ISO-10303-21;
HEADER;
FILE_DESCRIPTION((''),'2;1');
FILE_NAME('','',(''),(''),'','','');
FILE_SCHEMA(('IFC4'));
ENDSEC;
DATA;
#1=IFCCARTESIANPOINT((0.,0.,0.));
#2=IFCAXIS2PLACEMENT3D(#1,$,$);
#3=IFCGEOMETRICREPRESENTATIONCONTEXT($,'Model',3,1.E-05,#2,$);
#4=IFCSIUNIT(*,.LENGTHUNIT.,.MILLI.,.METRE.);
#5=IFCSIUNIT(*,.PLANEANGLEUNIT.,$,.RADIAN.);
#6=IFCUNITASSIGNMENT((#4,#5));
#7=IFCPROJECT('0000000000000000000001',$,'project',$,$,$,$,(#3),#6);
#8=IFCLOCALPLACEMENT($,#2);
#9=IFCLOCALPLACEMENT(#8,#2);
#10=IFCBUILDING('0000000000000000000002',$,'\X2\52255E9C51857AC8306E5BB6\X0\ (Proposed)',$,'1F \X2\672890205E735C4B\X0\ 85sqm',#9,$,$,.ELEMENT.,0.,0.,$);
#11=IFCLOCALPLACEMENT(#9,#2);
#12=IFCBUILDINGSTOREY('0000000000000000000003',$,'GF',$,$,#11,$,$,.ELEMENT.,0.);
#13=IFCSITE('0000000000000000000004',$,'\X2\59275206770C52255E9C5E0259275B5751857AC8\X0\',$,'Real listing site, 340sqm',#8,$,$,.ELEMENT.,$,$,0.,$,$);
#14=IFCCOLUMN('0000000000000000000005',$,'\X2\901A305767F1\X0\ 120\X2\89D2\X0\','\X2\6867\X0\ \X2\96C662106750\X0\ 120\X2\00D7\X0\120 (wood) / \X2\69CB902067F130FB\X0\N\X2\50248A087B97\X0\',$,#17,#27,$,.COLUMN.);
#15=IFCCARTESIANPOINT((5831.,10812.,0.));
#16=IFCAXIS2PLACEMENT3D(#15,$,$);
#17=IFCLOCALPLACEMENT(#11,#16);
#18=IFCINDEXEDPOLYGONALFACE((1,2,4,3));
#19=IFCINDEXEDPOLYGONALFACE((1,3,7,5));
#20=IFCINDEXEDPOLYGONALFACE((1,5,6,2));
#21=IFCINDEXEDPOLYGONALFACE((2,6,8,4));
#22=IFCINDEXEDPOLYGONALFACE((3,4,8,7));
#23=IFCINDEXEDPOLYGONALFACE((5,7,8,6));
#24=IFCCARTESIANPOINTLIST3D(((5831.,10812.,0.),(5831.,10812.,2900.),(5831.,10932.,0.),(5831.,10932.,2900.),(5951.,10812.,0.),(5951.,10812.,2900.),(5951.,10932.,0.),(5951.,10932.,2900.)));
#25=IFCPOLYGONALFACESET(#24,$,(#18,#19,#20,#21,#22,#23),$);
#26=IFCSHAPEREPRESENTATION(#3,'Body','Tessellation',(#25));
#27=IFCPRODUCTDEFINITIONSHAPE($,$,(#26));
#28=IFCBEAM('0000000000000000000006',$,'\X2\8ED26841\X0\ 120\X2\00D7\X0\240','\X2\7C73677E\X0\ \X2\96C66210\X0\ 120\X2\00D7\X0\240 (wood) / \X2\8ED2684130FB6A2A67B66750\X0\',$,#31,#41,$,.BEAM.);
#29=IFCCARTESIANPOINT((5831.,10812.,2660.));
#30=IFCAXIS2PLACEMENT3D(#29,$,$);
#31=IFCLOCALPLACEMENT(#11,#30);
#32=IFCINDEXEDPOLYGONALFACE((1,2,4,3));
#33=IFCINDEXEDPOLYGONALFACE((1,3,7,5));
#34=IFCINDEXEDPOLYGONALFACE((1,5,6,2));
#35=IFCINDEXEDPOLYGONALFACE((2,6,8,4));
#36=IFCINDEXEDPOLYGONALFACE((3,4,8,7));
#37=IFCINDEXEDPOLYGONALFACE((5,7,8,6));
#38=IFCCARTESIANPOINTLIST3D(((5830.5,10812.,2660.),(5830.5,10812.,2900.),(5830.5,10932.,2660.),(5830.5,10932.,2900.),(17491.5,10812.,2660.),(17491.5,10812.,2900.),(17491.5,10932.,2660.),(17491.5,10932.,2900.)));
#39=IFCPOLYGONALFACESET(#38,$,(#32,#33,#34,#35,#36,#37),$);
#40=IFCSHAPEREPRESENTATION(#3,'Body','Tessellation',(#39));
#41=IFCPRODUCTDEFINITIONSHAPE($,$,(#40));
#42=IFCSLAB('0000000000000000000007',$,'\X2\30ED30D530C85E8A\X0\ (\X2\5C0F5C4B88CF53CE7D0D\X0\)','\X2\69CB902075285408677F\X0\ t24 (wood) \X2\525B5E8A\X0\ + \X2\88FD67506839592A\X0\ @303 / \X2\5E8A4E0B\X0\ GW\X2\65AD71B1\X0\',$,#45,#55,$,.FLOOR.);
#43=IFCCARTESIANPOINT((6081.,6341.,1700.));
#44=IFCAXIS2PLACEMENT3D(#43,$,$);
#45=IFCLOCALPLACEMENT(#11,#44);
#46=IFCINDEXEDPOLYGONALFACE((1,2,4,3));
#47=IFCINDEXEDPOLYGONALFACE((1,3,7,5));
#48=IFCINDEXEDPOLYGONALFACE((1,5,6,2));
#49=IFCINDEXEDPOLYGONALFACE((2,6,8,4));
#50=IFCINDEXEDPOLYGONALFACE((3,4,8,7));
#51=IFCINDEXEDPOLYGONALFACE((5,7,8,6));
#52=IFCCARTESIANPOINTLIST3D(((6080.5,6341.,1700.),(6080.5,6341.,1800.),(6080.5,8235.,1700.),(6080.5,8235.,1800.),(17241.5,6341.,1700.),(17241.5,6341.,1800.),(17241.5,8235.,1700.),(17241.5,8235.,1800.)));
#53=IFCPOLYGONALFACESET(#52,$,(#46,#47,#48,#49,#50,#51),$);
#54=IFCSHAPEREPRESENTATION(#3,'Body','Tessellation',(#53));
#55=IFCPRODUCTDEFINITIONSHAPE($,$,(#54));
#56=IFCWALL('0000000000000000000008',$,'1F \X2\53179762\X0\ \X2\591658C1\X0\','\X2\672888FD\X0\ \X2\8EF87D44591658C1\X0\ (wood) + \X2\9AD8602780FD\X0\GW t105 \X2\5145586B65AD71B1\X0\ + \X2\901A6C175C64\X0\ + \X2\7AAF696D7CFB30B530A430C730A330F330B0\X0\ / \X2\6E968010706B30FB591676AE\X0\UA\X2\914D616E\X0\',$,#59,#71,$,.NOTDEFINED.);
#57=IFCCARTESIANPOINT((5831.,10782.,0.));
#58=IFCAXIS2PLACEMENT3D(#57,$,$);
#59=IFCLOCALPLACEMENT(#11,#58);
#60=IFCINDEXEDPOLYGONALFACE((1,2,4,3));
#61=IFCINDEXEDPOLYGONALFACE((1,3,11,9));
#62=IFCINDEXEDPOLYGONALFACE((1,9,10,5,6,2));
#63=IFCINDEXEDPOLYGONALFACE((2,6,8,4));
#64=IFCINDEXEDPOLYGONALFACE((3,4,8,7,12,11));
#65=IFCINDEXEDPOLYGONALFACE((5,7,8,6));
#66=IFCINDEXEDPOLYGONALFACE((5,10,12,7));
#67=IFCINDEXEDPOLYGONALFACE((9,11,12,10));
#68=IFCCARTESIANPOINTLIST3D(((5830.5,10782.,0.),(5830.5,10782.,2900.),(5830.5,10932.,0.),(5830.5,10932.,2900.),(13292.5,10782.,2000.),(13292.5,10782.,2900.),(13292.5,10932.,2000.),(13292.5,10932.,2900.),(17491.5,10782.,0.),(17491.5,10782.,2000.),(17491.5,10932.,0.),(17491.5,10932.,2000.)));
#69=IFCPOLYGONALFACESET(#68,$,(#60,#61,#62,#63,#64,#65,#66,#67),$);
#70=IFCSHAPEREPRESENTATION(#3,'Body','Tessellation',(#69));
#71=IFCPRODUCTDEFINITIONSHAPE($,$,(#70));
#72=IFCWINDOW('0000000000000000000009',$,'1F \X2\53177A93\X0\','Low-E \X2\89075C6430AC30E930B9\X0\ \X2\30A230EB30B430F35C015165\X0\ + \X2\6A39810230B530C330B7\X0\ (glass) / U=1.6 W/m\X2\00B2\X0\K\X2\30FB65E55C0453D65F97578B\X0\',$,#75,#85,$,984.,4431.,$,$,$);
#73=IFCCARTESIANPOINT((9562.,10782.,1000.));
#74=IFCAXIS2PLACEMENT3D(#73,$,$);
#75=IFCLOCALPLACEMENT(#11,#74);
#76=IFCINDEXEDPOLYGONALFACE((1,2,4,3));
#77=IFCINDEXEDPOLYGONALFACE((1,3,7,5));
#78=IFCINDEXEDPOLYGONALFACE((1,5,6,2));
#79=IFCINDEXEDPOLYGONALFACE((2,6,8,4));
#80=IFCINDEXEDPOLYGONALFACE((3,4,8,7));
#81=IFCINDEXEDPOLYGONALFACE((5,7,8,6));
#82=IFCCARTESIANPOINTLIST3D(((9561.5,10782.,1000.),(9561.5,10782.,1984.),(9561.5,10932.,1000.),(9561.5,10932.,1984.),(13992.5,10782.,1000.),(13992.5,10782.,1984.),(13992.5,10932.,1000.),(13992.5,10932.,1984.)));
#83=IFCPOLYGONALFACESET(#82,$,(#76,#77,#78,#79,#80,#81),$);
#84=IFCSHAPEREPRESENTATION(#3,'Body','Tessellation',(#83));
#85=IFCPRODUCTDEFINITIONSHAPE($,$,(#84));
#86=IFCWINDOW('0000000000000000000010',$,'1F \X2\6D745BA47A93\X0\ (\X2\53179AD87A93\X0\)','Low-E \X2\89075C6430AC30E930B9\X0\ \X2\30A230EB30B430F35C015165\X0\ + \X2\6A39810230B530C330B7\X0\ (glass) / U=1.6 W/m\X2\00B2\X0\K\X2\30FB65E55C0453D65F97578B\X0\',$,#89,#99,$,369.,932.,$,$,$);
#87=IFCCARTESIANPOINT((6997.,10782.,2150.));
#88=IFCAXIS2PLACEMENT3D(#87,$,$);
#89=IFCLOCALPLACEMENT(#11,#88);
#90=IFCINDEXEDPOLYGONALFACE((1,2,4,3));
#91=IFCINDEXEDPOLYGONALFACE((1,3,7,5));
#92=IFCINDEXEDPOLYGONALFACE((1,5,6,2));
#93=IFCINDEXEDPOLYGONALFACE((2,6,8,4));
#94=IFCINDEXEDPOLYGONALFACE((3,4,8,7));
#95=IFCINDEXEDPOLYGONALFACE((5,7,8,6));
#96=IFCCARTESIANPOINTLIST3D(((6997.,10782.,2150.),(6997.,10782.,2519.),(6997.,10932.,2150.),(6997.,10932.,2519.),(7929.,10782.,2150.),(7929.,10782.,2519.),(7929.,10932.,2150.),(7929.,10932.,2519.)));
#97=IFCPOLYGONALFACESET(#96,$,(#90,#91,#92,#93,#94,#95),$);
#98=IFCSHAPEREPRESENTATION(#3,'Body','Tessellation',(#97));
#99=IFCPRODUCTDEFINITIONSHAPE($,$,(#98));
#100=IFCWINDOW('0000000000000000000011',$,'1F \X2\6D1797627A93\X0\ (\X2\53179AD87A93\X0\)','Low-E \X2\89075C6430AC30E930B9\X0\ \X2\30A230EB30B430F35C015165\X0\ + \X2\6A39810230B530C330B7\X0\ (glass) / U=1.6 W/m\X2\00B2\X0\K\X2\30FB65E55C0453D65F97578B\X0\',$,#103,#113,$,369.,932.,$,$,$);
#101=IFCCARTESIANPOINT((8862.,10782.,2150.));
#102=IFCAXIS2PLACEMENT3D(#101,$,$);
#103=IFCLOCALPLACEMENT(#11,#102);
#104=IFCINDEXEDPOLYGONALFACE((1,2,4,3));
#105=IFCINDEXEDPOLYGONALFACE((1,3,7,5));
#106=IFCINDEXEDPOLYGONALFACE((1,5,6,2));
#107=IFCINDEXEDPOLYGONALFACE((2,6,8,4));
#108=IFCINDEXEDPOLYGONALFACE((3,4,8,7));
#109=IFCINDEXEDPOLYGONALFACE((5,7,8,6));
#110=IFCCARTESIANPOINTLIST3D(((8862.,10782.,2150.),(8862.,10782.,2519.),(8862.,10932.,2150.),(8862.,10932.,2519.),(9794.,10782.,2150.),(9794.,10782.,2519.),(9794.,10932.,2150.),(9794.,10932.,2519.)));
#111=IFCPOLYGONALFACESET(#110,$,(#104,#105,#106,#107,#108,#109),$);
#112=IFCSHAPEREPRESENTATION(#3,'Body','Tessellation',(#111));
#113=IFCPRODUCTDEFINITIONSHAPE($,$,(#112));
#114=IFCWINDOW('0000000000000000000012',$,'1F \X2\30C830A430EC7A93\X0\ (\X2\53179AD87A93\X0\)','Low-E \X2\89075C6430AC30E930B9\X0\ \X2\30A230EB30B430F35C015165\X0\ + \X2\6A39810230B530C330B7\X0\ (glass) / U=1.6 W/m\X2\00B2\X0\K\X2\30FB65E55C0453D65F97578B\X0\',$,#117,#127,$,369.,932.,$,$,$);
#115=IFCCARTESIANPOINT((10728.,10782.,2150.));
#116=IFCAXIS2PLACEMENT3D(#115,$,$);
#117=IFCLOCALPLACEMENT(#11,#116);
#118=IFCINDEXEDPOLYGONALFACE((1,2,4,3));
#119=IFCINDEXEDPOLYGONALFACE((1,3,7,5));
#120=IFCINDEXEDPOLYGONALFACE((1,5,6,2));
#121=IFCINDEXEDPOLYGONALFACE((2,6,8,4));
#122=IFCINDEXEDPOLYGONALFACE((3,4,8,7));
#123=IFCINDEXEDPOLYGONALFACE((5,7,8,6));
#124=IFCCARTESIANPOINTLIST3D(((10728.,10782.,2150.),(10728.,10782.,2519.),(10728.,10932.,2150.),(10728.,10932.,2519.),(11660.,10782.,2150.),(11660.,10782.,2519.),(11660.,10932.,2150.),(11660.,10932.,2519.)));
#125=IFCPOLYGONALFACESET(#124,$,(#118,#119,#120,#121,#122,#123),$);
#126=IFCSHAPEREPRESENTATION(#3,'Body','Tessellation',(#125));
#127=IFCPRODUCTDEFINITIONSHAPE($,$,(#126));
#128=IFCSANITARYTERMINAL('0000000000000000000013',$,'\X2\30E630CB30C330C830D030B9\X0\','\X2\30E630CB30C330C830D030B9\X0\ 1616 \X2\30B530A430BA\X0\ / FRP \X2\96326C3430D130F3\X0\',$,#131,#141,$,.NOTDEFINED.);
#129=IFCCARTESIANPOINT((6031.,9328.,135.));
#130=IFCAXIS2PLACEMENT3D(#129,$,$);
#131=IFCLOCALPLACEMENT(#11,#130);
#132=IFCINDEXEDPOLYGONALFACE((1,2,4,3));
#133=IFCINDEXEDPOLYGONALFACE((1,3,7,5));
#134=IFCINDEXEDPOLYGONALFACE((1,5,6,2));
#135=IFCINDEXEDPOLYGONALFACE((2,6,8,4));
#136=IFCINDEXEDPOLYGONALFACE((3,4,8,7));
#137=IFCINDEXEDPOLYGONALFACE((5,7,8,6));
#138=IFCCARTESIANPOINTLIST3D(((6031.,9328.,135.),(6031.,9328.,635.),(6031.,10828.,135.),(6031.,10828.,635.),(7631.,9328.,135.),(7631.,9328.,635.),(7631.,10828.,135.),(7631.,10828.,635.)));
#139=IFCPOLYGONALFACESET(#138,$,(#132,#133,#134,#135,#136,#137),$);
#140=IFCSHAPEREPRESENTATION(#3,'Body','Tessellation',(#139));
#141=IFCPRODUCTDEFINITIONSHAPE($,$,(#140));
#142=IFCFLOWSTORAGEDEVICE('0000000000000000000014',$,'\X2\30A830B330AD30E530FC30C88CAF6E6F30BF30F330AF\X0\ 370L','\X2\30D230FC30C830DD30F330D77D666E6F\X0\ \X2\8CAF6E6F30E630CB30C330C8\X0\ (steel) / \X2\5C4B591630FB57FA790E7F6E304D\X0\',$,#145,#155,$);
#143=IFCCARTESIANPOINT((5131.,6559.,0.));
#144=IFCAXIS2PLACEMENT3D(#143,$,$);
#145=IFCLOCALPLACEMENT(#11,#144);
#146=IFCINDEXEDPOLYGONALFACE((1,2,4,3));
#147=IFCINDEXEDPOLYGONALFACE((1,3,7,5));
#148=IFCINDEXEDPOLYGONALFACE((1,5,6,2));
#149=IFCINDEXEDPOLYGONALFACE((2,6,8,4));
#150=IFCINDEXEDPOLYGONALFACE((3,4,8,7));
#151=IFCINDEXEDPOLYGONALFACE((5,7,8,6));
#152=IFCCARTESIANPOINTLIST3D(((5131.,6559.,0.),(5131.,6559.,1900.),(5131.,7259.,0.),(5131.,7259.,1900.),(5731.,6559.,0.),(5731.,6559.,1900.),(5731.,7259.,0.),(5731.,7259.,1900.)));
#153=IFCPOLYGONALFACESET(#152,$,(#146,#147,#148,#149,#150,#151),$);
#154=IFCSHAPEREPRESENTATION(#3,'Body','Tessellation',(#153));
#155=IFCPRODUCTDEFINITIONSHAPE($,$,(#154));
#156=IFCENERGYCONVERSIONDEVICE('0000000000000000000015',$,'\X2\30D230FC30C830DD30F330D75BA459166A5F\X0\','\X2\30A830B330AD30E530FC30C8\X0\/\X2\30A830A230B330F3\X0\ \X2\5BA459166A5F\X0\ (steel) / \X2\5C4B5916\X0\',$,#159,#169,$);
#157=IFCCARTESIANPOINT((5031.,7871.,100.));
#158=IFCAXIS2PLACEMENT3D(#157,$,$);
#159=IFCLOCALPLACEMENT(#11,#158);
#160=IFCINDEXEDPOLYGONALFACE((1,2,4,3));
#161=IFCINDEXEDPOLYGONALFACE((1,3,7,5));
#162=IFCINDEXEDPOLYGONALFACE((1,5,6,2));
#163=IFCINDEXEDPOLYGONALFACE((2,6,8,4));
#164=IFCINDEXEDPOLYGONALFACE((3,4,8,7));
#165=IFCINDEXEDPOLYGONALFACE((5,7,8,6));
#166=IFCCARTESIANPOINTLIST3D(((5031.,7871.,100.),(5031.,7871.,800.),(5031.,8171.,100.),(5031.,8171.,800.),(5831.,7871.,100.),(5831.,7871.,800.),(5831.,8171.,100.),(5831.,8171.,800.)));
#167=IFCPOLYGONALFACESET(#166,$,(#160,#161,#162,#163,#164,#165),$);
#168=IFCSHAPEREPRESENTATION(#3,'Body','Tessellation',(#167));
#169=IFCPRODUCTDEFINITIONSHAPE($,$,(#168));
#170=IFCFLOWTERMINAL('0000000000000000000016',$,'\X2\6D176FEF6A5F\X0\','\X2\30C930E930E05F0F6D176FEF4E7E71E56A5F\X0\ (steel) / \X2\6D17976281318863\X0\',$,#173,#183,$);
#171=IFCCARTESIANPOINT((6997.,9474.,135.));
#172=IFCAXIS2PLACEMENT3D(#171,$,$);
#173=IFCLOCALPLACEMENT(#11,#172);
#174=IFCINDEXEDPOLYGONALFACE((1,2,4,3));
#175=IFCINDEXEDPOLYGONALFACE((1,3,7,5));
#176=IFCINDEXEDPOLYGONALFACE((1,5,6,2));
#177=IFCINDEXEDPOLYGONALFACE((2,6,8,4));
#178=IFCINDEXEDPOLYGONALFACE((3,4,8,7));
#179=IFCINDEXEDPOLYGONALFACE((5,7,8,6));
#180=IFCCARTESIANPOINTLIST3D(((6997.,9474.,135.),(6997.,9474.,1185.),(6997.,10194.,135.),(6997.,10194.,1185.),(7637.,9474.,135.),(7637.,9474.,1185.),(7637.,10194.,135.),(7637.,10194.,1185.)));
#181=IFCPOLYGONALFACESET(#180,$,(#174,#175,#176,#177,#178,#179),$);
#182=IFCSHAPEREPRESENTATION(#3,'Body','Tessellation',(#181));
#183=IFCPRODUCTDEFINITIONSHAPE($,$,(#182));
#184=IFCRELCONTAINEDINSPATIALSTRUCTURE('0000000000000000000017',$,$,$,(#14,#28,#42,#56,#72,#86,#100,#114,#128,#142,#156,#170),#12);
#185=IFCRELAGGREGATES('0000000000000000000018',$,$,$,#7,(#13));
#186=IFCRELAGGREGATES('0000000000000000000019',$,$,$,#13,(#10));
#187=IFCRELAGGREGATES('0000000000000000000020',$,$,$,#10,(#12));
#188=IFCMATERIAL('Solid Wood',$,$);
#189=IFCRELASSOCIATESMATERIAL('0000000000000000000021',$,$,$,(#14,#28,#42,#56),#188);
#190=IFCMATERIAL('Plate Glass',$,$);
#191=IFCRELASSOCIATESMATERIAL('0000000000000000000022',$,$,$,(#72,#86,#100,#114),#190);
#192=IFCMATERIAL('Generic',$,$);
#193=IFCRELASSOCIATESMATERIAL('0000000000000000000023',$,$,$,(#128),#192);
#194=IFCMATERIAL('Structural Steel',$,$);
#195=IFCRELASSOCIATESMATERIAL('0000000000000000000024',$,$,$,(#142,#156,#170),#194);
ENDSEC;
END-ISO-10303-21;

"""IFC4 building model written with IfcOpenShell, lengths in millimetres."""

from ifc_helpers import new_model, si_unit, frame, frame_2d, origin, place, context, project, spatial, rectangle, extrude, material, element, fill, save


model = new_model("IFC4")

# Units and contexts
model_context = context("Model", 3, precision=1e-05, world=origin())
ifc_project = project(units=[si_unit("LENGTHUNIT", "METRE", prefix="MILLI"), si_unit("PLANEANGLEUNIT", "RADIAN")], contexts=[model_context])

# Site, building, storey
site_placement = place(None, origin())
site = spatial("IfcSite", under=ifc_project, at=site_placement, Name="大分県別府市大字内竈", ObjectType="Real listing site, 340sqm", CompositionType="ELEMENT", RefElevation=0.0)
building_placement = place(site_placement, origin())
building = spatial("IfcBuilding", under=site, at=building_placement, Name="別府内竈の家 (Proposed)", ObjectType="1F 木造平屋 85sqm", CompositionType="ELEMENT", ElevationOfRefHeight=0.0, ElevationOfTerrain=0.0)
storey_placement = place(building_placement, origin())
storey = spatial("IfcBuildingStorey", under=building, at=storey_placement, Name="GF", CompositionType="ELEMENT", Elevation=0.0)

# Column
ifc_material_1 = material(Name="Solid Wood")
column_1_placement = place(storey_placement, frame((5831.0, 10812.0, 0.0)))
element("IfcColumn", 1, at=column_1_placement, inside=storey, material=ifc_material_1, Name="通し柱 120角", Description="桧 集成材 120×120 (wood) / 構造柱・N値計算", PredefinedType="COLUMN", context=model_context, shape_type="SweptSolid", body=[
    extrude(rectangle(XDim=120.0, YDim=120.0, at=frame_2d((60.0, 60.0))), frame((5831.0, 10812.0, 0.0)), (0.0, 0.0, 1.0), 2900.0),
])

# Beam
beam_1_placement = place(storey_placement, frame((5831.0, 10812.0, 2660.0)))
element("IfcBeam", 2, at=beam_1_placement, inside=storey, material=ifc_material_1, Name="軒桁 120×240", Description="米松 集成 120×240 (wood) / 軒桁・横架材", PredefinedType="BEAM", context=model_context, shape_type="SweptSolid", body=[
    extrude(rectangle(XDim=11661.0, YDim=120.0, at=frame_2d((5830.0, 60.0))), frame((5831.0, 10812.0, 2660.0)), (0.0, 0.0, 1.0), 240.0),
])

# Slab
slab_placement = place(storey_placement, frame((6081.0, 6341.0, 1700.0)))
element("IfcSlab", 3, at=slab_placement, inside=storey, material=ifc_material_1, Name="ロフト床 (小屋裏収納)", Description="構造用合板 t24 (wood) 剛床 + 製材根太 @303 / 床下 GW断熱", PredefinedType="FLOOR", context=model_context, shape_type="SweptSolid", body=[
    extrude(rectangle(XDim=11161.0, YDim=1894.0, at=frame_2d((5580.0, 947.0))), frame((6081.0, 6341.0, 1700.0)), (0.0, 0.0, 1.0), 100.0),
])

# Wall, openings, windows
wall_1_placement = place(storey_placement, frame((5831.0, 10782.0, 0.0)))
wall_1 = element("IfcWall", 4, at=wall_1_placement, inside=storey, material=ifc_material_1, Name="1F 北面 外壁", Description="木製 軸組外壁 (wood) + 高性能GW t105 充填断熱 + 通気層 + 窯業系サイディング / 準耐火・外皮UA配慮", PredefinedType="NOTDEFINED", context=model_context, shape_type="SweptSolid", body=[
    extrude(rectangle(XDim=11661.0, YDim=150.0, at=frame_2d((5830.0, 75.0))), frame((5831.0, 10782.0, 0.0)), (0.0, 0.0, 1.0), 2900.0),
])
opening_1_placement = place(storey_placement, frame((9562.0, 10782.0, 1000.0)))
opening_1 = element("IfcOpeningElement", 5, at=opening_1_placement, cuts=wall_1, PredefinedType="NOTDEFINED", context=model_context, shape_type="SweptSolid", body=[
    extrude(rectangle(XDim=4431.0, YDim=150.0, at=frame_2d((2215.0, 75.0))), frame((9562.0, 10782.0, 1000.0)), (0.0, 0.0, 1.0), 984.0),
])
opening_2_placement = place(storey_placement, frame((6997.0, 10782.0, 2150.0)))
opening_2 = element("IfcOpeningElement", 6, at=opening_2_placement, cuts=wall_1, PredefinedType="NOTDEFINED", context=model_context, shape_type="SweptSolid", body=[
    extrude(rectangle(XDim=932.0, YDim=150.0, at=frame_2d((466.0, 75.0))), frame((6997.0, 10782.0, 2150.0)), (0.0, 0.0, 1.0), 369.0),
])
opening_3_placement = place(storey_placement, frame((8862.0, 10782.0, 2150.0)))
opening_3 = element("IfcOpeningElement", 7, at=opening_3_placement, cuts=wall_1, PredefinedType="NOTDEFINED", context=model_context, shape_type="SweptSolid", body=[
    extrude(rectangle(XDim=932.0, YDim=150.0, at=frame_2d((466.0, 75.0))), frame((8862.0, 10782.0, 2150.0)), (0.0, 0.0, 1.0), 369.0),
])
opening_4_placement = place(storey_placement, frame((10728.0, 10782.0, 2150.0)))
opening_4 = element("IfcOpeningElement", 8, at=opening_4_placement, cuts=wall_1, PredefinedType="NOTDEFINED", context=model_context, shape_type="SweptSolid", body=[
    extrude(rectangle(XDim=932.0, YDim=150.0, at=frame_2d((466.0, 75.0))), frame((10728.0, 10782.0, 2150.0)), (0.0, 0.0, 1.0), 369.0),
])
ifc_material_2 = material(Name="Plate Glass")
window_1_placement = place(storey_placement, frame((9562.0, 10782.0, 1000.0)))
window_1 = element("IfcWindow", 9, at=window_1_placement, inside=storey, material=ifc_material_2, Name="1F 北窓", Description="Low-E 複層ガラス アルゴン封入 + 樹脂サッシ (glass) / U=1.6 W/m²K・日射取得型", OverallHeight=984.0, OverallWidth=4431.0, context=model_context, shape_type="SweptSolid", body=[
    extrude(rectangle(XDim=4431.0, YDim=150.0, at=frame_2d((2215.0, 75.0))), frame((9562.0, 10782.0, 1000.0)), (0.0, 0.0, 1.0), 984.0),
])
fill(opening_1, window_1)
window_2_placement = place(storey_placement, frame((6997.0, 10782.0, 2150.0)))
window_2 = element("IfcWindow", 10, at=window_2_placement, inside=storey, material=ifc_material_2, Name="1F 浴室窓 (北高窓)", Description="Low-E 複層ガラス アルゴン封入 + 樹脂サッシ (glass) / U=1.6 W/m²K・日射取得型", OverallHeight=369.0, OverallWidth=932.0, context=model_context, shape_type="SweptSolid", body=[
    extrude(rectangle(XDim=932.0, YDim=150.0, at=frame_2d((466.0, 75.0))), frame((6997.0, 10782.0, 2150.0)), (0.0, 0.0, 1.0), 369.0),
])
fill(opening_2, window_2)
window_3_placement = place(storey_placement, frame((8862.0, 10782.0, 2150.0)))
window_3 = element("IfcWindow", 11, at=window_3_placement, inside=storey, material=ifc_material_2, Name="1F 洗面窓 (北高窓)", Description="Low-E 複層ガラス アルゴン封入 + 樹脂サッシ (glass) / U=1.6 W/m²K・日射取得型", OverallHeight=369.0, OverallWidth=932.0, context=model_context, shape_type="SweptSolid", body=[
    extrude(rectangle(XDim=932.0, YDim=150.0, at=frame_2d((466.0, 75.0))), frame((8862.0, 10782.0, 2150.0)), (0.0, 0.0, 1.0), 369.0),
])
fill(opening_3, window_3)
window_4_placement = place(storey_placement, frame((10728.0, 10782.0, 2150.0)))
window_4 = element("IfcWindow", 12, at=window_4_placement, inside=storey, material=ifc_material_2, Name="1F トイレ窓 (北高窓)", Description="Low-E 複層ガラス アルゴン封入 + 樹脂サッシ (glass) / U=1.6 W/m²K・日射取得型", OverallHeight=369.0, OverallWidth=932.0, context=model_context, shape_type="SweptSolid", body=[
    extrude(rectangle(XDim=932.0, YDim=150.0, at=frame_2d((466.0, 75.0))), frame((10728.0, 10782.0, 2150.0)), (0.0, 0.0, 1.0), 369.0),
])
fill(opening_4, window_4)

# Sanitary terminal
ifc_material_3 = material(Name="Generic")
sanitary_terminal_placement = place(storey_placement, frame((6031.0, 9328.0, 135.0)))
element("IfcSanitaryTerminal", 13, at=sanitary_terminal_placement, inside=storey, material=ifc_material_3, Name="ユニットバス", Description="ユニットバス 1616 サイズ / FRP 防水パン", PredefinedType="NOTDEFINED", context=model_context, shape_type="SweptSolid", body=[
    extrude(rectangle(XDim=1600.0, YDim=1500.0, at=frame_2d((800.0, 750.0))), frame((6031.0, 9328.0, 135.0)), (0.0, 0.0, 1.0), 500.0),
])

# Flow storage device
ifc_material_4 = material(Name="Structural Steel")
flow_storage_device_placement = place(storey_placement, frame((5131.0, 6559.0, 0.0)))
element("IfcFlowStorageDevice", 14, at=flow_storage_device_placement, inside=storey, material=ifc_material_4, Name="エコキュート貯湯タンク 370L", Description="ヒートポンプ給湯 貯湯ユニット (steel) / 屋外・基礎置き", context=model_context, shape_type="SweptSolid", body=[
    extrude(rectangle(XDim=600.0, YDim=700.0, at=frame_2d((300.0, 350.0))), frame((5131.0, 6559.0, 0.0)), (0.0, 0.0, 1.0), 1900.0),
])

# Energy conversion device
energy_conversion_device_placement = place(storey_placement, frame((5031.0, 7871.0, 100.0)))
element("IfcEnergyConversionDevice", 15, at=energy_conversion_device_placement, inside=storey, material=ifc_material_4, Name="ヒートポンプ室外機", Description="エコキュート/エアコン 室外機 (steel) / 屋外", context=model_context, shape_type="SweptSolid", body=[
    extrude(rectangle(XDim=800.0, YDim=300.0, at=frame_2d((400.0, 150.0))), frame((5031.0, 7871.0, 100.0)), (0.0, 0.0, 1.0), 700.0),
])

# Flow terminal
flow_terminal_placement = place(storey_placement, frame((6997.0, 9474.0, 135.0)))
element("IfcFlowTerminal", 16, at=flow_terminal_placement, inside=storey, material=ifc_material_4, Name="洗濯機", Description="ドラム式洗濯乾燥機 (steel) / 洗面脱衣", context=model_context, shape_type="SweptSolid", body=[
    extrude(rectangle(XDim=640.0, YDim=720.0, at=frame_2d((320.0, 360.0))), frame((6997.0, 9474.0, 135.0)), (0.0, 0.0, 1.0), 1050.0),
])

save(model, "model.ifc")
